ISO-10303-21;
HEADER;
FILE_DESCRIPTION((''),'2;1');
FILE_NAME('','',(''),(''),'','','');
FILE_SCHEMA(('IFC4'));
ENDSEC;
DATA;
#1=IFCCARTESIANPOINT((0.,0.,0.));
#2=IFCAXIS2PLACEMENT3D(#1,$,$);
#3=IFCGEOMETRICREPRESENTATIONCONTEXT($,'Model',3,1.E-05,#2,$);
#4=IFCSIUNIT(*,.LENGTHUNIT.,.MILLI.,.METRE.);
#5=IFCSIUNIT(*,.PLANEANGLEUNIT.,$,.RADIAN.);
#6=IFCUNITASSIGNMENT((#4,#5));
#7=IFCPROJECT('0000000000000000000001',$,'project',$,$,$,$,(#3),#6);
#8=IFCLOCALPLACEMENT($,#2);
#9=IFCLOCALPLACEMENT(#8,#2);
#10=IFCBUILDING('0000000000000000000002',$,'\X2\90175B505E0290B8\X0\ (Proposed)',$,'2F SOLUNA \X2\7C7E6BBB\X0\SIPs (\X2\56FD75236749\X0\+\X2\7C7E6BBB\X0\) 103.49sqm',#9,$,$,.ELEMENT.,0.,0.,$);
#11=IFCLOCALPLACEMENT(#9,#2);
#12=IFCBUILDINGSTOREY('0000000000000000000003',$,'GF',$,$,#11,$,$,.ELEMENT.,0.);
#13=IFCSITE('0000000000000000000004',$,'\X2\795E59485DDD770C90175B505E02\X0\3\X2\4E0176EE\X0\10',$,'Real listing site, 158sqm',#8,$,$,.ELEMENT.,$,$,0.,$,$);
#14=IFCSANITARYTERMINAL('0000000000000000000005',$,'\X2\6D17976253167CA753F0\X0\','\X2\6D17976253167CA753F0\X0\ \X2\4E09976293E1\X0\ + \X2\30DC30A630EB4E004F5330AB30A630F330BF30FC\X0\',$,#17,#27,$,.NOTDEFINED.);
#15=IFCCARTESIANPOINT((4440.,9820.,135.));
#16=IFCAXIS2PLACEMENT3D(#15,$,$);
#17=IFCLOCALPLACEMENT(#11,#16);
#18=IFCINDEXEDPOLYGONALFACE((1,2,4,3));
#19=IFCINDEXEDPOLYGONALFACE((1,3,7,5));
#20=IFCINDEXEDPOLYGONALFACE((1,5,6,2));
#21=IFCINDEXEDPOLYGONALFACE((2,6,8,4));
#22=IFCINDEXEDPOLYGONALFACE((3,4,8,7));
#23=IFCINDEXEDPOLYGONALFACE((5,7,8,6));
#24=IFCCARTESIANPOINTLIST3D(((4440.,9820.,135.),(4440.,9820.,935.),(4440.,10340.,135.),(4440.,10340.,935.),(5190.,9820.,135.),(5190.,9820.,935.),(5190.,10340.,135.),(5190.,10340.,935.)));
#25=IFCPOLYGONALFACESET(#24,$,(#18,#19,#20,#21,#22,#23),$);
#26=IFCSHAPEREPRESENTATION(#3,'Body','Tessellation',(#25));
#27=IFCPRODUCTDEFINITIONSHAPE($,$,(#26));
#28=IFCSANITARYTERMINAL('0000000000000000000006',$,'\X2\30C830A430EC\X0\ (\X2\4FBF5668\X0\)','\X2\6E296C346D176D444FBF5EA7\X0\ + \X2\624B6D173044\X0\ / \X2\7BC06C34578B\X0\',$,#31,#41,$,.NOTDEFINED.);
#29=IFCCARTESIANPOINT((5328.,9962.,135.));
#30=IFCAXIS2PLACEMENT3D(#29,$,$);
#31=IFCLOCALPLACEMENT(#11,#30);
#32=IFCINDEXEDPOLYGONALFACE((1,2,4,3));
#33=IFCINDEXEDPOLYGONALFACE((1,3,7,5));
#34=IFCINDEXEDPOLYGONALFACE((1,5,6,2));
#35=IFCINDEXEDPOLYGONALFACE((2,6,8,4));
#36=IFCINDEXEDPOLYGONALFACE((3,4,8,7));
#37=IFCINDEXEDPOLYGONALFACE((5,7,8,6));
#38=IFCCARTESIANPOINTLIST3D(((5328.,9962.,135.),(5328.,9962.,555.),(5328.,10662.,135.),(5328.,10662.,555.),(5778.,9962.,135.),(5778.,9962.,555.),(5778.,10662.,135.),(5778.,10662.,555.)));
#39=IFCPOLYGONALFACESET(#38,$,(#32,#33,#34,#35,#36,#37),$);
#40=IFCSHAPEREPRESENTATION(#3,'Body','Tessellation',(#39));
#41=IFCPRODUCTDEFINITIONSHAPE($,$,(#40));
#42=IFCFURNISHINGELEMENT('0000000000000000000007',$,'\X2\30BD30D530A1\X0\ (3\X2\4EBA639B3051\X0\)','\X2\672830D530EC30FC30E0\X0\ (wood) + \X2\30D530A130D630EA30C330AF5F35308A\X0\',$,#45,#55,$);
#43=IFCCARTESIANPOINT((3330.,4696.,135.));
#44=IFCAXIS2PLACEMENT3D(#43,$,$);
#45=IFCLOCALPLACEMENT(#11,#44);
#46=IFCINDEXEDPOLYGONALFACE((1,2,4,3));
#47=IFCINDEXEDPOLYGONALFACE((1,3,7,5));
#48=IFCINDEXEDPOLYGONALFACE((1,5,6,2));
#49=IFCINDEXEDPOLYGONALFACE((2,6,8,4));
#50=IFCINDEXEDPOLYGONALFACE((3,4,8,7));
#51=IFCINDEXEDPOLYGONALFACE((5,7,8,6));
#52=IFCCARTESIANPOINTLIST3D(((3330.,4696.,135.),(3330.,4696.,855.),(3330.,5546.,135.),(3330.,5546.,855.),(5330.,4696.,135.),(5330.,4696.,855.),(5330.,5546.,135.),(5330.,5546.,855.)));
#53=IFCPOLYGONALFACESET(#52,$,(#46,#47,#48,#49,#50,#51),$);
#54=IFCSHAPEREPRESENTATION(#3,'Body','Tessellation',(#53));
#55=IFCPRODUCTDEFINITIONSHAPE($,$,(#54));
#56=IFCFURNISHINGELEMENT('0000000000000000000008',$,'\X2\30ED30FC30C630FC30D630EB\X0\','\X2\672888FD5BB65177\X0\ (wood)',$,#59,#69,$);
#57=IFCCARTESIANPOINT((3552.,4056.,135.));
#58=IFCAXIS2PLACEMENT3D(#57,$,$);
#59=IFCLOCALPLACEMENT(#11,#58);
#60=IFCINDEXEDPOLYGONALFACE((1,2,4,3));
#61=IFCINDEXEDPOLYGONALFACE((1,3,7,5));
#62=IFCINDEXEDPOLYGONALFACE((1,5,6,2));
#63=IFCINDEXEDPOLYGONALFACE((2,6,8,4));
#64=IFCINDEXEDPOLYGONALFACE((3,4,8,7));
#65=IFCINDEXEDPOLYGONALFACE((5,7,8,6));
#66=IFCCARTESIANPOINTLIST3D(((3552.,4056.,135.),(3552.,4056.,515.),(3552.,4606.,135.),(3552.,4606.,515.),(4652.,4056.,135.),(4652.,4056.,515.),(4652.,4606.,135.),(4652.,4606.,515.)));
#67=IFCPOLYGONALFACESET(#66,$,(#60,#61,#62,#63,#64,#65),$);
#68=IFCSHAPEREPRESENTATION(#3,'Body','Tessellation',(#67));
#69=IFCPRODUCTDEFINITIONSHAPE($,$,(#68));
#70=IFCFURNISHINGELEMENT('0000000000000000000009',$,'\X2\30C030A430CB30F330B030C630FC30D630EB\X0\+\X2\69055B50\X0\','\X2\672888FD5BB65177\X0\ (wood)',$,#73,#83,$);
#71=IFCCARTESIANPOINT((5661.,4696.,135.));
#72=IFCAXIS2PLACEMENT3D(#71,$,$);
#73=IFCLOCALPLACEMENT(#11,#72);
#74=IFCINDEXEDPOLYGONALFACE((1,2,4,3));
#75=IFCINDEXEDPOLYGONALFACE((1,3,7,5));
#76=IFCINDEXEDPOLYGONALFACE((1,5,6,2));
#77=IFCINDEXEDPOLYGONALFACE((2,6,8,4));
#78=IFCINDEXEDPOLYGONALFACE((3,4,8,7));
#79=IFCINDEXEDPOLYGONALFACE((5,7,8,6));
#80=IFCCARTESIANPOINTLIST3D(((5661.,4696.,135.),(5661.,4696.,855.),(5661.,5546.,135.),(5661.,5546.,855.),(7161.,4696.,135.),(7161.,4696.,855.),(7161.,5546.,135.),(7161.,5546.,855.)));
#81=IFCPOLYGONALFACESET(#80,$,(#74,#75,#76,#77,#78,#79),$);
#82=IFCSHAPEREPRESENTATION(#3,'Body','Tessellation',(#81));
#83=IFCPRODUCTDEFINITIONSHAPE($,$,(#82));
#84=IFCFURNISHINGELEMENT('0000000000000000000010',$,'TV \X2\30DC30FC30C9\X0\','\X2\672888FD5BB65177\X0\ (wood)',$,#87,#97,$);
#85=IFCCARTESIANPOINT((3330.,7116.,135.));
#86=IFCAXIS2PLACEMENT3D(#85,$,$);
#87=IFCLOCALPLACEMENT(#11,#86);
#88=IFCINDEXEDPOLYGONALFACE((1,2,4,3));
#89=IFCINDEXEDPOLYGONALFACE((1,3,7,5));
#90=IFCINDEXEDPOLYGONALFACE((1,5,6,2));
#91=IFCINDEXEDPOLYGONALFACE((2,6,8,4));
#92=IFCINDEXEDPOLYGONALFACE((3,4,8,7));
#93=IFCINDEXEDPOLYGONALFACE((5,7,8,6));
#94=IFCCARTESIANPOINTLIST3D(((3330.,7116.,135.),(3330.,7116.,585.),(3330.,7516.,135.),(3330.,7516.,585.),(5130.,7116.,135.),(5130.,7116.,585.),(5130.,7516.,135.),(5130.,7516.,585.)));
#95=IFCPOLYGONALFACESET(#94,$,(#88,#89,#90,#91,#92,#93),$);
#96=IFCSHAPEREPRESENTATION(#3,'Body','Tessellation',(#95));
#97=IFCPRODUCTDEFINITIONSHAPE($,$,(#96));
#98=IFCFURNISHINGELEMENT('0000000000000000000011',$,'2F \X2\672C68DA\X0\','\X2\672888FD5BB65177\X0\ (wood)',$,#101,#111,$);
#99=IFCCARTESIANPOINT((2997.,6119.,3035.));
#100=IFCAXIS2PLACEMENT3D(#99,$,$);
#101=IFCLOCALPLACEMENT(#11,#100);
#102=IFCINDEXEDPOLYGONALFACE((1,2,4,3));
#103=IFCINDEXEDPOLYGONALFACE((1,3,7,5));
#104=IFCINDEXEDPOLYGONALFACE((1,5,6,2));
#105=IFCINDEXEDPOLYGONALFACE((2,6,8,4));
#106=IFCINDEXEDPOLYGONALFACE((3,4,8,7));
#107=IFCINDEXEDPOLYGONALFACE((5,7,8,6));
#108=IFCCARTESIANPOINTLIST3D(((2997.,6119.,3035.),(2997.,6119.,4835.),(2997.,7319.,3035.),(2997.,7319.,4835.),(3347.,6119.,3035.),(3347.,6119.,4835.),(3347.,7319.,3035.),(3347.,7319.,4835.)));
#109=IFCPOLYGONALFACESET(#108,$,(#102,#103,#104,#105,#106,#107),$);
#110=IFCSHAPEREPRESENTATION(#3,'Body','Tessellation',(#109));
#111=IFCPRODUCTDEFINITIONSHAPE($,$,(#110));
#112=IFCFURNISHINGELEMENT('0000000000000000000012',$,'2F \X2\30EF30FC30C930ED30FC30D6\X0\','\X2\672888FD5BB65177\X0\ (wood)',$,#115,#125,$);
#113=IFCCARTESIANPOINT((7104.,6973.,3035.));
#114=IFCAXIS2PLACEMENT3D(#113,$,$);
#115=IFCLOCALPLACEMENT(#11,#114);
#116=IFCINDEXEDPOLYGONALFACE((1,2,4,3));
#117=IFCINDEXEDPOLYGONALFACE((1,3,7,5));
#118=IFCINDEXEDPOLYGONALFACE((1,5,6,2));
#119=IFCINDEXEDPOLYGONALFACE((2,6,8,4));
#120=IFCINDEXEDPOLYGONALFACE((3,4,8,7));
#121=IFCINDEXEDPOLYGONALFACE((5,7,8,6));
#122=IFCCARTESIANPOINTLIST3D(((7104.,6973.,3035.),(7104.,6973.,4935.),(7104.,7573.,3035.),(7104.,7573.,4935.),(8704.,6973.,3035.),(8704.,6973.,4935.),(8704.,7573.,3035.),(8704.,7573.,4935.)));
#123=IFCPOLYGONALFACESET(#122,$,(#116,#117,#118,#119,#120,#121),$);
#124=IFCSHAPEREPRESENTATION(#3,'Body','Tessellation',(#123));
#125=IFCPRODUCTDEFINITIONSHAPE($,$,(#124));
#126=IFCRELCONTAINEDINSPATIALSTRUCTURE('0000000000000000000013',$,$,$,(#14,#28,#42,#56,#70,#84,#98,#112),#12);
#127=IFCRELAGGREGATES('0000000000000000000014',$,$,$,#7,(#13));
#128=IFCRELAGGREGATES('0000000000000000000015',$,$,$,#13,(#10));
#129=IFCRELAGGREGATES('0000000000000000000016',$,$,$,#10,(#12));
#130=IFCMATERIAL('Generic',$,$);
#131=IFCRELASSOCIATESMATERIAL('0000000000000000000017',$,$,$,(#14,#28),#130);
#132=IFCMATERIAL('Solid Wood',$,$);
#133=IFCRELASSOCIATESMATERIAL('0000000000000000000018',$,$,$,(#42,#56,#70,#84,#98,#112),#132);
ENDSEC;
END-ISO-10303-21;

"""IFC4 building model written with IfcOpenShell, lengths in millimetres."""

from ifc_helpers import new_model, si_unit, frame, frame_2d, origin, place, context, project, spatial, rectangle, extrude, material, element, save


model = new_model("IFC4")

# Units and contexts
model_context = context("Model", 3, precision=1e-05, world=origin())
ifc_project = project(units=[si_unit("LENGTHUNIT", "METRE", prefix="MILLI"), si_unit("PLANEANGLEUNIT", "RADIAN")], contexts=[model_context])

# Site, building, storey
site_placement = place(None, origin())
site = spatial("IfcSite", under=ifc_project, at=site_placement, Name="神奈川県逗子市3丁目10", ObjectType="Real listing site, 158sqm", CompositionType="ELEMENT", RefElevation=0.0)
building_placement = place(site_placement, origin())
building = spatial("IfcBuilding", under=site, at=building_placement, Name="逗子市邸 (Proposed)", ObjectType="2F SOLUNA 籾殻SIPs (国産杉+籾殻) 103.49sqm", CompositionType="ELEMENT", ElevationOfRefHeight=0.0, ElevationOfTerrain=0.0)
storey_placement = place(building_placement, origin())
storey = spatial("IfcBuildingStorey", under=building, at=storey_placement, Name="GF", CompositionType="ELEMENT", Elevation=0.0)

# Shared definitions
ifc_material_1 = material(Name="Generic")

# Shared definitions
ifc_material_2 = material(Name="Solid Wood")

# Sanitary terminals
sanitary_terminal_1_placement = place(storey_placement, frame((4440.0, 9820.0, 135.0)))
element("IfcSanitaryTerminal", 1, at=sanitary_terminal_1_placement, inside=storey, material=ifc_material_1, Name="洗面化粧台", Description="洗面化粧台 三面鏡 + ボウル一体カウンター", PredefinedType="NOTDEFINED", context=model_context, shape_type="SweptSolid", body=[
    extrude(rectangle(XDim=750.0, YDim=520.0, at=frame_2d((375.0, 260.0))), frame((4440.0, 9820.0, 135.0)), (0.0, 0.0, 1.0), 800.0),
])
sanitary_terminal_2_placement = place(storey_placement, frame((5328.0, 9962.0, 135.0)))
element("IfcSanitaryTerminal", 2, at=sanitary_terminal_2_placement, inside=storey, material=ifc_material_1, Name="トイレ (便器)", Description="温水洗浄便座 + 手洗い / 節水型", PredefinedType="NOTDEFINED", context=model_context, shape_type="SweptSolid", body=[
    extrude(rectangle(XDim=450.0, YDim=700.0, at=frame_2d((225.0, 350.0))), frame((5328.0, 9962.0, 135.0)), (0.0, 0.0, 1.0), 420.0),
])

# Furnishing elements
furnishing_1_placement = place(storey_placement, frame((3330.0, 4696.0, 135.0)))
element("IfcFurnishingElement", 3, at=furnishing_1_placement, inside=storey, material=ifc_material_2, Name="ソファ (3人掛け)", Description="木フレーム (wood) + ファブリック張り", context=model_context, shape_type="SweptSolid", body=[
    extrude(rectangle(XDim=2000.0, YDim=850.0, at=frame_2d((1000.0, 425.0))), frame((3330.0, 4696.0, 135.0)), (0.0, 0.0, 1.0), 720.0),
])
furnishing_2_placement = place(storey_placement, frame((3552.0, 4056.0, 135.0)))
element("IfcFurnishingElement", 4, at=furnishing_2_placement, inside=storey, material=ifc_material_2, Name="ローテーブル", Description="木製家具 (wood)", context=model_context, shape_type="SweptSolid", body=[
    extrude(rectangle(XDim=1100.0, YDim=550.0, at=frame_2d((550.0, 275.0))), frame((3552.0, 4056.0, 135.0)), (0.0, 0.0, 1.0), 380.0),
])
furnishing_3_placement = place(storey_placement, frame((5661.0, 4696.0, 135.0)))
element("IfcFurnishingElement", 5, at=furnishing_3_placement, inside=storey, material=ifc_material_2, Name="ダイニングテーブル+椅子", Description="木製家具 (wood)", context=model_context, shape_type="SweptSolid", body=[
    extrude(rectangle(XDim=1500.0, YDim=850.0, at=frame_2d((750.0, 425.0))), frame((5661.0, 4696.0, 135.0)), (0.0, 0.0, 1.0), 720.0),
])
furnishing_4_placement = place(storey_placement, frame((3330.0, 7116.0, 135.0)))
element("IfcFurnishingElement", 6, at=furnishing_4_placement, inside=storey, material=ifc_material_2, Name="TV ボード", Description="木製家具 (wood)", context=model_context, shape_type="SweptSolid", body=[
    extrude(rectangle(XDim=1800.0, YDim=400.0, at=frame_2d((900.0, 200.0))), frame((3330.0, 7116.0, 135.0)), (0.0, 0.0, 1.0), 450.0),
])
furnishing_5_placement = place(storey_placement, frame((2997.0, 6119.0, 3035.0)))
element("IfcFurnishingElement", 7, at=furnishing_5_placement, inside=storey, material=ifc_material_2, Name="2F 本棚", Description="木製家具 (wood)", context=model_context, shape_type="SweptSolid", body=[
    extrude(rectangle(XDim=350.0, YDim=1200.0, at=frame_2d((175.0, 600.0))), frame((2997.0, 6119.0, 3035.0)), (0.0, 0.0, 1.0), 1800.0),
])
furnishing_6_placement = place(storey_placement, frame((7104.0, 6973.0, 3035.0)))
element("IfcFurnishingElement", 8, at=furnishing_6_placement, inside=storey, material=ifc_material_2, Name="2F ワードローブ", Description="木製家具 (wood)", context=model_context, shape_type="SweptSolid", body=[
    extrude(rectangle(XDim=1600.0, YDim=600.0, at=frame_2d((800.0, 300.0))), frame((7104.0, 6973.0, 3035.0)), (0.0, 0.0, 1.0), 1900.0),
])

save(model, "model.ifc")
